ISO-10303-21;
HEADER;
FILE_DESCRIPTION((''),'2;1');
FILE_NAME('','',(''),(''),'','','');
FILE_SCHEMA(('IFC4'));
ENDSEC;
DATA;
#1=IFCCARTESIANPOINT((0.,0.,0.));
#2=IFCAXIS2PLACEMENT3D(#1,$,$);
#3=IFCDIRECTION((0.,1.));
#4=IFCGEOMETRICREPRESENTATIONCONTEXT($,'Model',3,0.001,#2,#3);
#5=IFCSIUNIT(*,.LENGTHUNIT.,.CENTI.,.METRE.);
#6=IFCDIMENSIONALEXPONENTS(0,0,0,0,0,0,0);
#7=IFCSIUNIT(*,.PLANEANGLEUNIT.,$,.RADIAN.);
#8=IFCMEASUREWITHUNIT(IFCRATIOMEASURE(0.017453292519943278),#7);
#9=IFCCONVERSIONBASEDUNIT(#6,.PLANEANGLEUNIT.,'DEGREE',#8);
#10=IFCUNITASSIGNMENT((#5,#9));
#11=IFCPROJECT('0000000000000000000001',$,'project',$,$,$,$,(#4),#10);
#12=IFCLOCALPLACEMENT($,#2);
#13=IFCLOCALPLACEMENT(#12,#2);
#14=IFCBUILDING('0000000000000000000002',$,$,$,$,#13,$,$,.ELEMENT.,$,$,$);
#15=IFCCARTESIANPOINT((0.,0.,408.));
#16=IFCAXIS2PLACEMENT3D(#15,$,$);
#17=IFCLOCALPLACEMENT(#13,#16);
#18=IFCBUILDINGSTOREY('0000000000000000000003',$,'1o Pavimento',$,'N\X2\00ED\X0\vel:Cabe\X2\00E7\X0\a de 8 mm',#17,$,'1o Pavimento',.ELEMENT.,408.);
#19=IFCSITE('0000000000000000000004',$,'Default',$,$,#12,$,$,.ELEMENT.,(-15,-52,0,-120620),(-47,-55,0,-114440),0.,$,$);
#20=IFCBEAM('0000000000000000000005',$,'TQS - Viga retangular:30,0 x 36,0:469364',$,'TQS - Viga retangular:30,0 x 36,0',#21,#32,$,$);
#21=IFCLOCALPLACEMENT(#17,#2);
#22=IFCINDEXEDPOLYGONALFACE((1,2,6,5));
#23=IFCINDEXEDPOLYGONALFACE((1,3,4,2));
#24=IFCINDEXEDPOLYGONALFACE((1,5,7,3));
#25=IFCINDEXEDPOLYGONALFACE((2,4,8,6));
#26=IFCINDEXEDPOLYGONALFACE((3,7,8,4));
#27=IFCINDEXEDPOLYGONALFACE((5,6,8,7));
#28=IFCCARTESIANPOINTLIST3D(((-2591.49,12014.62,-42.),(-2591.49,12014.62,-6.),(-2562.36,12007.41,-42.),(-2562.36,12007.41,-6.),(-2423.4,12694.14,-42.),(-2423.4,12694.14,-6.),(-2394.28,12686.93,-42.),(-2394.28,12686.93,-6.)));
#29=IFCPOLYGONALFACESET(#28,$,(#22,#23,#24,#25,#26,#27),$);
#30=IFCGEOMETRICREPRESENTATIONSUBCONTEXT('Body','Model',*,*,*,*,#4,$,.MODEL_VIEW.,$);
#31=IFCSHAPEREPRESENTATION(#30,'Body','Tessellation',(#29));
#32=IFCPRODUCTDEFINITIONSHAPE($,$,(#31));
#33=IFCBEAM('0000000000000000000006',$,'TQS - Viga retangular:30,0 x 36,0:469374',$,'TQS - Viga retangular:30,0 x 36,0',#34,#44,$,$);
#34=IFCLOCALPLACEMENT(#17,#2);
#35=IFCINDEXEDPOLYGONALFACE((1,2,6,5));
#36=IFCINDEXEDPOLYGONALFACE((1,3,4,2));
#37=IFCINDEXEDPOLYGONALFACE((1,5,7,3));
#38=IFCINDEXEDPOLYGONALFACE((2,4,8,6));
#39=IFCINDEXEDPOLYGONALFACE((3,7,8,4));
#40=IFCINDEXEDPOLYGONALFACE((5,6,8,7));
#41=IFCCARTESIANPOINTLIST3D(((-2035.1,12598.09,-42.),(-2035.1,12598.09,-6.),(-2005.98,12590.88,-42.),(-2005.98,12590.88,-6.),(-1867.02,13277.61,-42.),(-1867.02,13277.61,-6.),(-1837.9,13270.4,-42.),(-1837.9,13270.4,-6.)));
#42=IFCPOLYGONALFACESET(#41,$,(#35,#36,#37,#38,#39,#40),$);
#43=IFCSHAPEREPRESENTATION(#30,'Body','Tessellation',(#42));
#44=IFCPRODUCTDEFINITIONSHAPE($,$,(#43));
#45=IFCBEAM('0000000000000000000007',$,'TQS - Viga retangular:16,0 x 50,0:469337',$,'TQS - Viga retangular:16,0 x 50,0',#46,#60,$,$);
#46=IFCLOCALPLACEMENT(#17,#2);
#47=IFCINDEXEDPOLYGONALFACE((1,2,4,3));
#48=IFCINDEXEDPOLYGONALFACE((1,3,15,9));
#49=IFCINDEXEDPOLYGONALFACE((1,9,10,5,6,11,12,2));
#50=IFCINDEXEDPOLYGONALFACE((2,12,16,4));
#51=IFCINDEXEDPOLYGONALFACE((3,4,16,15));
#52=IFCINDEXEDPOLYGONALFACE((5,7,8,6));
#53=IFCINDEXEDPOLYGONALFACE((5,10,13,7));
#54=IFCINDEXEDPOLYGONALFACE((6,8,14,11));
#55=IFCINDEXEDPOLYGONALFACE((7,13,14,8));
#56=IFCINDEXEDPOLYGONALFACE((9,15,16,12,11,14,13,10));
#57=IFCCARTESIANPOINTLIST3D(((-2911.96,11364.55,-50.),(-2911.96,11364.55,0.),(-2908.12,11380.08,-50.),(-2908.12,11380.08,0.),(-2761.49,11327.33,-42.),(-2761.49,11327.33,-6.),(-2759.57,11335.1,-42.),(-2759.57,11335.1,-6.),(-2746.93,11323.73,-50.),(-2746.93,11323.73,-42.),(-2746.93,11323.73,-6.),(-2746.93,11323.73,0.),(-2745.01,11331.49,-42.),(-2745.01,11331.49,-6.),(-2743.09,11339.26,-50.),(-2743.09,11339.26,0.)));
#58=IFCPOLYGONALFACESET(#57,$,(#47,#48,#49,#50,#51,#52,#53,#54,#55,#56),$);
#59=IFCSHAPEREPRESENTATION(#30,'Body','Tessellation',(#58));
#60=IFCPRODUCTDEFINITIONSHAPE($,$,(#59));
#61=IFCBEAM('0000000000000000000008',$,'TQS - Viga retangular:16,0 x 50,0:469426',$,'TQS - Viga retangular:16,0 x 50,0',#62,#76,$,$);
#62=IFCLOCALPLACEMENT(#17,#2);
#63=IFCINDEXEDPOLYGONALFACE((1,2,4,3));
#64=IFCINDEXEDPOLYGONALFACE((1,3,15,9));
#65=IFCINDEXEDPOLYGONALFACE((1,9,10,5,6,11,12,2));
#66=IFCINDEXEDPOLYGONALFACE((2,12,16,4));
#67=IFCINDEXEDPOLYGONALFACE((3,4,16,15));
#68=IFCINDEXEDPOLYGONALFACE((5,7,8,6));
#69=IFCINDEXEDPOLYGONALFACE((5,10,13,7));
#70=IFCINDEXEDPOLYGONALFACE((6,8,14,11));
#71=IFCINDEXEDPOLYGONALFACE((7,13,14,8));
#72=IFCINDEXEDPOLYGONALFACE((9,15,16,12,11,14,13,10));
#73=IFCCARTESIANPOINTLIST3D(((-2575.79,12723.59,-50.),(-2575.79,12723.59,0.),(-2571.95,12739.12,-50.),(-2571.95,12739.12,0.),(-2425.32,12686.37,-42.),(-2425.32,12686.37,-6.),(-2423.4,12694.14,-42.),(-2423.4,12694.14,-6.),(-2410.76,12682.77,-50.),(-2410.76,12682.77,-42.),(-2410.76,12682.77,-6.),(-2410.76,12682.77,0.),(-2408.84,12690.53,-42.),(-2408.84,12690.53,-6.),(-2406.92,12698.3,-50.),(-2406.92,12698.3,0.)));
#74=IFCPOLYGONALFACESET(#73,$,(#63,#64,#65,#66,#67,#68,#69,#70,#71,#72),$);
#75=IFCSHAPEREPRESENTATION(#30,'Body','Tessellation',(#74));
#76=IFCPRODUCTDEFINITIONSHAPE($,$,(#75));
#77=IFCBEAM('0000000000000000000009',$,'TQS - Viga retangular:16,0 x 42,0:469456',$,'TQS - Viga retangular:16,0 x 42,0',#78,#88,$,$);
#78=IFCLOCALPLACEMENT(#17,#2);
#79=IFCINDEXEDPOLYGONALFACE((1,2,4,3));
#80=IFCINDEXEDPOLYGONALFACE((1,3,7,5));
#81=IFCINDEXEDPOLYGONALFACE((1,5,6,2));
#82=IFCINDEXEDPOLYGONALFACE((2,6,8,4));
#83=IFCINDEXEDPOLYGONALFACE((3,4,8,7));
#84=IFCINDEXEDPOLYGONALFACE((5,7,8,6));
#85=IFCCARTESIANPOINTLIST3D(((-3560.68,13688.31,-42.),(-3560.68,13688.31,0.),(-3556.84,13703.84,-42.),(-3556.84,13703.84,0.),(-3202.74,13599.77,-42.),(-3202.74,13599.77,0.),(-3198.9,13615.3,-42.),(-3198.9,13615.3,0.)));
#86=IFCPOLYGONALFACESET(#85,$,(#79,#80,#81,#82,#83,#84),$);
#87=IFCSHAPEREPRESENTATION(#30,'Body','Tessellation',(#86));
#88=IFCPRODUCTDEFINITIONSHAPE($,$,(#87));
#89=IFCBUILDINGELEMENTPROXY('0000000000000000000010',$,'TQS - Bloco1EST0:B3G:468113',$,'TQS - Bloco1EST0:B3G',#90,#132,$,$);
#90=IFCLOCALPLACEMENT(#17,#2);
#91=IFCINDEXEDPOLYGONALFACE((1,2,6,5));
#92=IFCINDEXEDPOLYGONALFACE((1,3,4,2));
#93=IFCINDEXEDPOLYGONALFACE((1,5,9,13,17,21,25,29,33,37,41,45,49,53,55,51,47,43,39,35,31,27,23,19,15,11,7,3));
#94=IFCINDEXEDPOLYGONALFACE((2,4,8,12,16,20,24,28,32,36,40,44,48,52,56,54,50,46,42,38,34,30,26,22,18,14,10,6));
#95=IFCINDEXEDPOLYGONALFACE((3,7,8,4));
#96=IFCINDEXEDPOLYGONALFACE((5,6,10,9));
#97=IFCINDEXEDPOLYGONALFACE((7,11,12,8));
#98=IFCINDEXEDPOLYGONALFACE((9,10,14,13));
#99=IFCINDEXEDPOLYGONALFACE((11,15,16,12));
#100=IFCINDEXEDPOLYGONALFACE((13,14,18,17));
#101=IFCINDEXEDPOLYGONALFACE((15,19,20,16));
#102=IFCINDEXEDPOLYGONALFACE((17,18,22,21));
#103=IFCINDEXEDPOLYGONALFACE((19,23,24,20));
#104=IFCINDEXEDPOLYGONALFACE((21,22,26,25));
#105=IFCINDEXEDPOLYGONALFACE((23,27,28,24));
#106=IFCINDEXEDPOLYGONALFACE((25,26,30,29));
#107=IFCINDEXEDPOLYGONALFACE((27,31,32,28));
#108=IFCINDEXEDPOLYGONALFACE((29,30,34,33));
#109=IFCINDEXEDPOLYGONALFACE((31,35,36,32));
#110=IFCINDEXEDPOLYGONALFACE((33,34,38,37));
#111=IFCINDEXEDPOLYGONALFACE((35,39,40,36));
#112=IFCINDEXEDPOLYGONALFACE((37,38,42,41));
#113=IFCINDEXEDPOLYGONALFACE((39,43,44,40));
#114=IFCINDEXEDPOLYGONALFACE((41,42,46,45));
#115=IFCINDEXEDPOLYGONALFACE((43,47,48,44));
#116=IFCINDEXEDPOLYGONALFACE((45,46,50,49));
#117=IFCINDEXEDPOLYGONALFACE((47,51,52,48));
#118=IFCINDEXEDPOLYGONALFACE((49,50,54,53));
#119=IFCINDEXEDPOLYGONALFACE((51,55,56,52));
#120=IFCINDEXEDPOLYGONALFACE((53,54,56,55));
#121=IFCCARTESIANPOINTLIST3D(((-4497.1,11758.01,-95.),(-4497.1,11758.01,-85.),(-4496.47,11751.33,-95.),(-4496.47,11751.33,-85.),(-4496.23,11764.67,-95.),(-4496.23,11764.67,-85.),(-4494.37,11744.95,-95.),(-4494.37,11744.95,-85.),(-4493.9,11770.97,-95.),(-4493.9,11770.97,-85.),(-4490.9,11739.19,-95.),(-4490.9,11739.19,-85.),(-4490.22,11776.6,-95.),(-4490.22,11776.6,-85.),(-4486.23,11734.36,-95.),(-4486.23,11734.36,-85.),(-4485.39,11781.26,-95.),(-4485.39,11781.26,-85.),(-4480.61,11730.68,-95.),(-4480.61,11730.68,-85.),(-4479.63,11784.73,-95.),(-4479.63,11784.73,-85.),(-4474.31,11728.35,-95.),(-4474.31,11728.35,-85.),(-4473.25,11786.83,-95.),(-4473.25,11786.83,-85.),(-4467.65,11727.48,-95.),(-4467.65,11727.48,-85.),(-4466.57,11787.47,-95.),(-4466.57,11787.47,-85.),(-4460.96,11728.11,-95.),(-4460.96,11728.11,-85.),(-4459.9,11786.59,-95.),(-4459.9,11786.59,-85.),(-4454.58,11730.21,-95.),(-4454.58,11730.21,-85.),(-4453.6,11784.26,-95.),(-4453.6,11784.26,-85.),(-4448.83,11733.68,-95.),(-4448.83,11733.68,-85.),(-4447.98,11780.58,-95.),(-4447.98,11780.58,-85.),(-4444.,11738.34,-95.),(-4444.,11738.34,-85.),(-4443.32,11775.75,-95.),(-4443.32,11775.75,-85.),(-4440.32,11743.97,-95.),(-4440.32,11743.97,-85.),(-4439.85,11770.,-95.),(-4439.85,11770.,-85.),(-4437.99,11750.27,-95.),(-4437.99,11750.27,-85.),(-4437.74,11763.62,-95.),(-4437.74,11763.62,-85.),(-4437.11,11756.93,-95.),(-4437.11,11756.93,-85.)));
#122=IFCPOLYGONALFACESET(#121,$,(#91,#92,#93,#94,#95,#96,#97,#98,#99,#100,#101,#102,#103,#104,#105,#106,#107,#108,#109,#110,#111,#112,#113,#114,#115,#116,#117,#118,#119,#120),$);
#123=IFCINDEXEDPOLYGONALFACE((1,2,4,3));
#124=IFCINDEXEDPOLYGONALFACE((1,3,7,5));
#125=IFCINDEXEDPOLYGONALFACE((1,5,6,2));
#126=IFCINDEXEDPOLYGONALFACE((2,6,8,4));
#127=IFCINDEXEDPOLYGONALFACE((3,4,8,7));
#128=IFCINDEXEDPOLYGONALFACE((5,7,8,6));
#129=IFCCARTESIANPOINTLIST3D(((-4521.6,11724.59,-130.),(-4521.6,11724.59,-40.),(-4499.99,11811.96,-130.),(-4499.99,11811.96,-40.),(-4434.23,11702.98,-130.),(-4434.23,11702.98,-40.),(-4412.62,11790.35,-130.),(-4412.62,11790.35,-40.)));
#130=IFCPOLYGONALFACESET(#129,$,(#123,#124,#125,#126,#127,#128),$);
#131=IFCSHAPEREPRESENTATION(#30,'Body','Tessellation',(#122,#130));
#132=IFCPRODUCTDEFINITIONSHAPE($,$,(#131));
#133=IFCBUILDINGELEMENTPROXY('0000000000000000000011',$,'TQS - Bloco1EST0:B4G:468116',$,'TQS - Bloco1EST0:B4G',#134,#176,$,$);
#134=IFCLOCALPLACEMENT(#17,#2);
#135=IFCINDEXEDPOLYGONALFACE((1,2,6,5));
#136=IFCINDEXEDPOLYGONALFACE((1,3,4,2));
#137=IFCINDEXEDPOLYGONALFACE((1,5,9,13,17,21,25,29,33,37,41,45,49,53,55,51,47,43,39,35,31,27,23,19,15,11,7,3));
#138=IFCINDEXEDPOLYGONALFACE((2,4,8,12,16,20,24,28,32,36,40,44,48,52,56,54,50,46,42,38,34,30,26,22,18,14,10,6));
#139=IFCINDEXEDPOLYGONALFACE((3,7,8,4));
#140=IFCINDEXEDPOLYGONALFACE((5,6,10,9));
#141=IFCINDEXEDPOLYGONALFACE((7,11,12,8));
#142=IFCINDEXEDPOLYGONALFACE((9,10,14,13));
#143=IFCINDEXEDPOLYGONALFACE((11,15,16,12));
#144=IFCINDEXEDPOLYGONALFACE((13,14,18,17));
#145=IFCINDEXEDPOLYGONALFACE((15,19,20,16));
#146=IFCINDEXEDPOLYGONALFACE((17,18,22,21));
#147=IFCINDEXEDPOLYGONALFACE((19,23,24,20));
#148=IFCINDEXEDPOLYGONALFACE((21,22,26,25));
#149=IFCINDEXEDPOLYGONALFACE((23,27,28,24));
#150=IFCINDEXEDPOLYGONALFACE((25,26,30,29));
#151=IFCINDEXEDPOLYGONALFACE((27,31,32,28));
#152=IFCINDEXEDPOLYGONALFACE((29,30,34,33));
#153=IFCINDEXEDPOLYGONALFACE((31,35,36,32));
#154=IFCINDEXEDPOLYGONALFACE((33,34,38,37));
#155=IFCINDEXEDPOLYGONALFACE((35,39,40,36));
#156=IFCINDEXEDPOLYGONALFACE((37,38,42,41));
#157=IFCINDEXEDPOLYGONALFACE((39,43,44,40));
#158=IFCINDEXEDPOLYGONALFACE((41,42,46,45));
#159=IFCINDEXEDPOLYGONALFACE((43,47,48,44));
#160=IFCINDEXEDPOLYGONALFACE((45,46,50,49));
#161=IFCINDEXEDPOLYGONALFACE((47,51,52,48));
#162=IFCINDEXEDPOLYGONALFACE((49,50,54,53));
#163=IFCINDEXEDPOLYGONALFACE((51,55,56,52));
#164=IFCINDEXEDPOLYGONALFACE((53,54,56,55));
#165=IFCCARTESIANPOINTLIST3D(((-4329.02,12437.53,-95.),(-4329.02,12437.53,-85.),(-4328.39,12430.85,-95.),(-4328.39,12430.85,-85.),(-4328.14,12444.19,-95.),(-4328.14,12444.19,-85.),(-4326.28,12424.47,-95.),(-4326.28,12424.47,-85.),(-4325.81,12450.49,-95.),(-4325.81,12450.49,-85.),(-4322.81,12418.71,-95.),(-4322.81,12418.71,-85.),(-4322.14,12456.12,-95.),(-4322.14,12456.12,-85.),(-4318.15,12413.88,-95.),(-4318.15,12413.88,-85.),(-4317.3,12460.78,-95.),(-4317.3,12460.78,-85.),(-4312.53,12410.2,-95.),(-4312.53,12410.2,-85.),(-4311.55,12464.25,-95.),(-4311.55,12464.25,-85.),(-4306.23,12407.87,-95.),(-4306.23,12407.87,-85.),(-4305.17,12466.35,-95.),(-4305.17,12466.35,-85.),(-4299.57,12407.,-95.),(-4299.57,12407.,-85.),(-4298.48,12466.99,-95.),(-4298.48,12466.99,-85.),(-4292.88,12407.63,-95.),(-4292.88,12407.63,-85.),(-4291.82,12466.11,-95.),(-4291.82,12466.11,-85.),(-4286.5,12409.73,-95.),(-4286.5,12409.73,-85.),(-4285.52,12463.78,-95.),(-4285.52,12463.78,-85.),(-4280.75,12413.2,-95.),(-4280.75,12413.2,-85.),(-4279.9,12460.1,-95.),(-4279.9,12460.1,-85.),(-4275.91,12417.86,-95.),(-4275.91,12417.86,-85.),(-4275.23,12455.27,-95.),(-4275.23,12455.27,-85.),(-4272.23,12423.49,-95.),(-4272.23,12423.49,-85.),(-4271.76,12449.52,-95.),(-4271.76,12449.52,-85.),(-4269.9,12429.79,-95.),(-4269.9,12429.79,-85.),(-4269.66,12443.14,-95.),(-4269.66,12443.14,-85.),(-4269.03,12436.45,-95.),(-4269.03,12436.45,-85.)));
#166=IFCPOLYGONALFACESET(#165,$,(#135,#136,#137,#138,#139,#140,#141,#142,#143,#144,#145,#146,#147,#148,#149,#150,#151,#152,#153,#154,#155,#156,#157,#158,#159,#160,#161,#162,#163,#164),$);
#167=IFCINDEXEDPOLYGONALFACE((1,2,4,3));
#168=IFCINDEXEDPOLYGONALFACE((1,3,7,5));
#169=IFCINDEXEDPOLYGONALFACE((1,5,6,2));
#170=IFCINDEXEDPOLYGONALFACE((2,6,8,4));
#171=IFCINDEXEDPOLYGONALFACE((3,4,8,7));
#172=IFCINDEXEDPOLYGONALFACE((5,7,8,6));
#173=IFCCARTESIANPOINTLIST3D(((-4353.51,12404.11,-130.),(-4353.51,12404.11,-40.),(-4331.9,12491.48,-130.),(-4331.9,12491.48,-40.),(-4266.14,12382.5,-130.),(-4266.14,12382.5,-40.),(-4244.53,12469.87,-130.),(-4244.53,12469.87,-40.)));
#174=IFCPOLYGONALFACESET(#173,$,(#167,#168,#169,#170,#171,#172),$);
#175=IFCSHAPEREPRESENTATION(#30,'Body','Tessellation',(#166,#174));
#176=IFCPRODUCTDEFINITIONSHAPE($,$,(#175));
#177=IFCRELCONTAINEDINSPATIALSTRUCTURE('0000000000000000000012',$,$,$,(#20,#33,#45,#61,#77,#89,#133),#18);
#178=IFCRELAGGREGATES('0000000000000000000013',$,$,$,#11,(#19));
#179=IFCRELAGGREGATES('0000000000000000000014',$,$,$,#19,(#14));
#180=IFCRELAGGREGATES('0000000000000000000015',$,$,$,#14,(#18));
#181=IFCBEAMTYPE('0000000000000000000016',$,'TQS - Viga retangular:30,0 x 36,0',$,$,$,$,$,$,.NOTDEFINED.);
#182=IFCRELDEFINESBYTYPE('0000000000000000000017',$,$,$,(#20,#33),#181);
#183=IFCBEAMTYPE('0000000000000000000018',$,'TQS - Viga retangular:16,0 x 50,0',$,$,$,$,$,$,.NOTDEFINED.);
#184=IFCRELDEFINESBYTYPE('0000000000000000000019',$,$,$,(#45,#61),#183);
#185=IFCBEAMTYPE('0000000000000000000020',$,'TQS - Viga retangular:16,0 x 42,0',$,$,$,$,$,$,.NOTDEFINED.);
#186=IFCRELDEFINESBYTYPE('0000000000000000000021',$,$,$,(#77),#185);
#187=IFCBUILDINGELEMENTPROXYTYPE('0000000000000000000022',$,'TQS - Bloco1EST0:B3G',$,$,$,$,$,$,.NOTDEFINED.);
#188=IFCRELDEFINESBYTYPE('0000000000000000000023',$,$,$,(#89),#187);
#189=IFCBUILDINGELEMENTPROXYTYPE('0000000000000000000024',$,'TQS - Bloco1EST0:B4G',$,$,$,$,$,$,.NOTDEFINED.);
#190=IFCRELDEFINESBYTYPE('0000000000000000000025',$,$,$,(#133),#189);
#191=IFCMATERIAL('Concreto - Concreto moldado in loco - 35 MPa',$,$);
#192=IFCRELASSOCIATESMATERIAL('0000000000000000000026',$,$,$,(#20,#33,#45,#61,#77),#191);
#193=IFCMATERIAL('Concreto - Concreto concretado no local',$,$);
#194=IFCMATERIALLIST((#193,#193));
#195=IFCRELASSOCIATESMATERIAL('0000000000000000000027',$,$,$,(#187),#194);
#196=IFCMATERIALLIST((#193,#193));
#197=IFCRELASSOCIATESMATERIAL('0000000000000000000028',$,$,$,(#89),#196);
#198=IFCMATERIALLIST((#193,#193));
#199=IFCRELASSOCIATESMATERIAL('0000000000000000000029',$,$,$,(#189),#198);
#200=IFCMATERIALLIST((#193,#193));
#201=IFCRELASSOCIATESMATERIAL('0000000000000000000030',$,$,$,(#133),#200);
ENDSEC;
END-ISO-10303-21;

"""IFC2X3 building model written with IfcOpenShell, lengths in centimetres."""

from ifc_helpers import new_model, entity, si_unit, converted_unit, direction, frame, frame_2d, origin, origin_2d_with_axis, place, context, subcontext, project, spatial, polyline, rectangle, circle, extrude, boolean, clip, bounded_halfspace, source, transform, mapped, material, material_list, type_object, type_shapes, element, save


model = new_model("IFC2X3")

# Units and contexts
model_context = context("Model", 3, precision=0.001, world=origin(), true_north=direction((0.0, 1.0)))
body_context = subcontext(model_context, "Body", "Model", "MODEL_VIEW")
ifc_project = project(units=[si_unit("LENGTHUNIT", "METRE", prefix="CENTI"), converted_unit("PLANEANGLEUNIT", "DEGREE", entity("IfcRatioMeasure", 0.017453292519943278), si_unit("PLANEANGLEUNIT", "RADIAN"), dimensions=[0, 0, 0, 0, 0, 0, 0])], contexts=[model_context])

# Site, building, storey
site_placement = place(None, origin())
site = spatial("IfcSite", under=ifc_project, at=site_placement, Name="Default", CompositionType="ELEMENT", RefLatitude=(-15, -52, 0, -120620), RefLongitude=(-47, -55, 0, -114440), RefElevation=0.0)
building_placement = place(site_placement, origin())
building = spatial("IfcBuilding", under=site, at=building_placement, CompositionType="ELEMENT")
storey_placement = place(building_placement, frame((0.0, 0.0, 408.0)))
storey = spatial("IfcBuildingStorey", under=building, at=storey_placement, Name="1o Pavimento", ObjectType="Nível:Cabeça de 8 mm", LongName="1o Pavimento", CompositionType="ELEMENT", Elevation=408.0)

# Beams
ifc_material_1 = material(Name="Concreto - Concreto moldado in loco - 35 MPa")
beam_type_1 = type_object("IfcBeamType", Name="TQS - Viga retangular:30,0 x 36,0", PredefinedType="NOTDEFINED")
beam_1_placement = place(storey_placement, frame((-2576.92, 12011.01, -6.0), z_axis=(0.0, 0.0, 1.0), x_axis=(0.240122, 0.970743, 0.0)))
element("IfcBeam", 1, at=beam_1_placement, inside=storey, type_object=beam_type_1, material=ifc_material_1, Name="TQS - Viga retangular:30,0 x 36,0:469364", ObjectType="TQS - Viga retangular:30,0 x 36,0", context=body_context, shape_type="SweptSolid", body=[
    extrude(rectangle(XDim=36.0, YDim=30.0, at=frame_2d((0.0, 0.0), x_axis=(1.0, 0.0))), frame((0.0, 0.0, -18.0), z_axis=(1.0, 0.0, 0.0), x_axis=(0.0, 0.0, -1.0)), (0.0, 0.0, 1.0), 700.0),
])
beam_2_placement = place(storey_placement, frame((-2020.54, 12594.48, -6.0), z_axis=(0.0, 0.0, 1.0), x_axis=(0.240122, 0.970743, 0.0)))
element("IfcBeam", 2, at=beam_2_placement, inside=storey, type_object=beam_type_1, material=ifc_material_1, Name="TQS - Viga retangular:30,0 x 36,0:469374", ObjectType="TQS - Viga retangular:30,0 x 36,0", context=body_context, shape_type="SweptSolid", body=[
    extrude(rectangle(XDim=36.0, YDim=30.0, at=frame_2d((0.0, 0.0), x_axis=(1.0, 0.0))), frame((0.0, 0.0, -18.0), z_axis=(1.0, 0.0, 0.0), x_axis=(0.0, 0.0, -1.0)), (0.0, 0.0, 1.0), 700.0),
])
beam_type_2 = type_object("IfcBeamType", Name="TQS - Viga retangular:16,0 x 50,0", PredefinedType="NOTDEFINED")
beam_3_placement = place(storey_placement, frame((-2745.01, 11331.49, 0.0), z_axis=(0.0, 0.0, 1.0), x_axis=(-0.970743, 0.240122, 0.0)))
element("IfcBeam", 3, at=beam_3_placement, inside=storey, type_object=beam_type_2, material=ifc_material_1, Name="TQS - Viga retangular:16,0 x 50,0:469337", ObjectType="TQS - Viga retangular:16,0 x 50,0", context=body_context, shape_type="SweptSolid", body=[
    boolean("DIFFERENCE", clip(extrude(rectangle(XDim=50.0, YDim=16.0, at=frame_2d((0.0, 0.0), x_axis=(1.0, 0.0))), frame((0.0, 0.0, -25.0), z_axis=(1.0, 0.0, 0.0), x_axis=(0.0, 0.0, -1.0)), (0.0, 0.0, 1.0), 170.0), bounded_halfspace(frame((15.0, 0.0, -42.0), z_axis=(-1.0, 0.0, 0.0), x_axis=(0.0, 1.0, 0.0)), False, frame((0.0, 0.0, -25.0), z_axis=(1.0, 0.0, 0.0), x_axis=(0.0, 0.0, -1.0)), polyline([(17.0, 0.0), (-19.0, 0.0), (-19.0, 8.0), (-9.0, 8.0), (17.0, 8.0), (17.0, 0.0)]))), extrude(rectangle(XDim=36.0, YDim=8.0, at=frame_2d((0.0, 0.0), x_axis=(0.0, 1.0))), frame((0.0, 4.0, -24.0), z_axis=(-1.0, 0.0, 0.0), x_axis=(0.0, -1.0, 0.0)), (0.0, 0.0, -1.0), 15.0)),
])
beam_4_placement = place(storey_placement, frame((-2408.84, 12690.53, 0.0), z_axis=(0.0, 0.0, 1.0), x_axis=(-0.970743, 0.240122, 0.0)))
element("IfcBeam", 4, at=beam_4_placement, inside=storey, type_object=beam_type_2, material=ifc_material_1, Name="TQS - Viga retangular:16,0 x 50,0:469426", ObjectType="TQS - Viga retangular:16,0 x 50,0", context=body_context, shape_type="SweptSolid", body=[
    boolean("DIFFERENCE", clip(extrude(rectangle(XDim=50.0, YDim=16.0, at=frame_2d((0.0, 0.0), x_axis=(1.0, 0.0))), frame((0.0, 0.0, -25.0), z_axis=(1.0, 0.0, 0.0), x_axis=(0.0, 0.0, -1.0)), (0.0, 0.0, 1.0), 170.0), bounded_halfspace(frame((15.0, 0.0, -42.0), z_axis=(-1.0, 0.0, 0.0), x_axis=(0.0, 1.0, 0.0)), False, frame((0.0, 0.0, -25.0), z_axis=(1.0, 0.0, 0.0), x_axis=(0.0, 0.0, -1.0)), polyline([(17.0, 0.0), (-19.0, 0.0), (-19.0, 8.0), (-9.0, 8.0), (17.0, 8.0), (17.0, 0.0)]))), extrude(rectangle(XDim=36.0, YDim=8.0, at=frame_2d((0.0, 0.0), x_axis=(0.0, 1.0))), frame((0.0, 4.0, -24.0), z_axis=(-1.0, 0.0, 0.0), x_axis=(0.0, -1.0, 0.0)), (0.0, 0.0, -1.0), 15.0)),
])
beam_type_3 = type_object("IfcBeamType", Name="TQS - Viga retangular:16,0 x 42,0", PredefinedType="NOTDEFINED")
beam_5_placement = place(storey_placement, frame((-3193.05, 13605.61, 0.0), z_axis=(0.0, 0.0, 1.0), x_axis=(-0.970743, 0.240122, 0.0)))
element("IfcBeam", 5, at=beam_5_placement, inside=storey, type_object=beam_type_3, material=ifc_material_1, Name="TQS - Viga retangular:16,0 x 42,0:469456", ObjectType="TQS - Viga retangular:16,0 x 42,0", context=body_context, shape_type="SweptSolid", body=[
    extrude(rectangle(XDim=42.0, YDim=16.0, at=frame_2d((0.0, 0.0), x_axis=(1.0, 0.0))), frame((8.0, 0.0, -21.0), z_axis=(1.0, 0.0, 0.0), x_axis=(0.0, 0.0, -1.0)), (0.0, 0.0, 1.0), 368.73),
])

# Building element proxies
ifc_material_2 = material(Name="Concreto - Concreto concretado no local")
ifc_material_list_1 = material_list([ifc_material_2, ifc_material_2])
ifc_material_list_2 = material_list([ifc_material_2, ifc_material_2])
building_element_proxy_type_1 = type_object("IfcBuildingElementProxyType", Name="TQS - Bloco1EST0:B3G", PredefinedType="NOTDEFINED", material=ifc_material_list_2)
shared_shape_1 = source(origin(), body_context, "Body", "SweptSolid", [
    extrude(circle(Radius=30.0, at=frame_2d((0.0, 0.0), x_axis=(1.0, 0.0))), frame((0.0, 0.0, -55.0)), (0.0, 0.0, 1.0), 10.0),
    extrude(rectangle(XDim=90.0, YDim=90.0, at=origin_2d_with_axis()), frame((0.0, 0.0, -90.0), z_axis=(0.0, 0.0, 1.0), x_axis=(-1.0, 0.0, 0.0)), (0.0, 0.0, 1.0), 90.0),
])
type_shapes(building_element_proxy_type_1, [shared_shape_1])
proxy_1_placement = place(storey_placement, frame((-4467.11, 11757.47, -40.0), z_axis=(0.0, 0.0, 1.0), x_axis=(0.240122, 0.970743, 0.0)))
element("IfcBuildingElementProxy", 6, at=proxy_1_placement, inside=storey, type_object=building_element_proxy_type_1, material=ifc_material_list_1, Name="TQS - Bloco1EST0:B3G:468113", ObjectType="TQS - Bloco1EST0:B3G", context=body_context, shape_type="MappedRepresentation", body=[
    mapped(shared_shape_1, transform((0.0, 0.0, 0.0), scale=1.0)),
])
ifc_material_list_3 = material_list([ifc_material_2, ifc_material_2])
ifc_material_list_4 = material_list([ifc_material_2, ifc_material_2])
building_element_proxy_type_2 = type_object("IfcBuildingElementProxyType", Name="TQS - Bloco1EST0:B4G", PredefinedType="NOTDEFINED", material=ifc_material_list_4)
shared_shape_2 = source(origin(), body_context, "Body", "SweptSolid", [
    extrude(circle(Radius=30.0, at=frame_2d((0.0, 0.0), x_axis=(1.0, 0.0))), frame((0.0, 0.0, -55.0)), (0.0, 0.0, 1.0), 10.0),
    extrude(rectangle(XDim=90.0, YDim=90.0, at=origin_2d_with_axis()), frame((0.0, 0.0, -90.0), z_axis=(0.0, 0.0, 1.0), x_axis=(-1.0, 0.0, 0.0)), (0.0, 0.0, 1.0), 90.0),
])
type_shapes(building_element_proxy_type_2, [shared_shape_2])
proxy_2_placement = place(storey_placement, frame((-4299.02, 12436.99, -40.0), z_axis=(0.0, 0.0, 1.0), x_axis=(0.240122, 0.970743, 0.0)))
element("IfcBuildingElementProxy", 7, at=proxy_2_placement, inside=storey, type_object=building_element_proxy_type_2, material=ifc_material_list_3, Name="TQS - Bloco1EST0:B4G:468116", ObjectType="TQS - Bloco1EST0:B4G", context=body_context, shape_type="MappedRepresentation", body=[
    mapped(shared_shape_2, transform((0.0, 0.0, 0.0), scale=1.0)),
])

save(model, "model.ifc")
